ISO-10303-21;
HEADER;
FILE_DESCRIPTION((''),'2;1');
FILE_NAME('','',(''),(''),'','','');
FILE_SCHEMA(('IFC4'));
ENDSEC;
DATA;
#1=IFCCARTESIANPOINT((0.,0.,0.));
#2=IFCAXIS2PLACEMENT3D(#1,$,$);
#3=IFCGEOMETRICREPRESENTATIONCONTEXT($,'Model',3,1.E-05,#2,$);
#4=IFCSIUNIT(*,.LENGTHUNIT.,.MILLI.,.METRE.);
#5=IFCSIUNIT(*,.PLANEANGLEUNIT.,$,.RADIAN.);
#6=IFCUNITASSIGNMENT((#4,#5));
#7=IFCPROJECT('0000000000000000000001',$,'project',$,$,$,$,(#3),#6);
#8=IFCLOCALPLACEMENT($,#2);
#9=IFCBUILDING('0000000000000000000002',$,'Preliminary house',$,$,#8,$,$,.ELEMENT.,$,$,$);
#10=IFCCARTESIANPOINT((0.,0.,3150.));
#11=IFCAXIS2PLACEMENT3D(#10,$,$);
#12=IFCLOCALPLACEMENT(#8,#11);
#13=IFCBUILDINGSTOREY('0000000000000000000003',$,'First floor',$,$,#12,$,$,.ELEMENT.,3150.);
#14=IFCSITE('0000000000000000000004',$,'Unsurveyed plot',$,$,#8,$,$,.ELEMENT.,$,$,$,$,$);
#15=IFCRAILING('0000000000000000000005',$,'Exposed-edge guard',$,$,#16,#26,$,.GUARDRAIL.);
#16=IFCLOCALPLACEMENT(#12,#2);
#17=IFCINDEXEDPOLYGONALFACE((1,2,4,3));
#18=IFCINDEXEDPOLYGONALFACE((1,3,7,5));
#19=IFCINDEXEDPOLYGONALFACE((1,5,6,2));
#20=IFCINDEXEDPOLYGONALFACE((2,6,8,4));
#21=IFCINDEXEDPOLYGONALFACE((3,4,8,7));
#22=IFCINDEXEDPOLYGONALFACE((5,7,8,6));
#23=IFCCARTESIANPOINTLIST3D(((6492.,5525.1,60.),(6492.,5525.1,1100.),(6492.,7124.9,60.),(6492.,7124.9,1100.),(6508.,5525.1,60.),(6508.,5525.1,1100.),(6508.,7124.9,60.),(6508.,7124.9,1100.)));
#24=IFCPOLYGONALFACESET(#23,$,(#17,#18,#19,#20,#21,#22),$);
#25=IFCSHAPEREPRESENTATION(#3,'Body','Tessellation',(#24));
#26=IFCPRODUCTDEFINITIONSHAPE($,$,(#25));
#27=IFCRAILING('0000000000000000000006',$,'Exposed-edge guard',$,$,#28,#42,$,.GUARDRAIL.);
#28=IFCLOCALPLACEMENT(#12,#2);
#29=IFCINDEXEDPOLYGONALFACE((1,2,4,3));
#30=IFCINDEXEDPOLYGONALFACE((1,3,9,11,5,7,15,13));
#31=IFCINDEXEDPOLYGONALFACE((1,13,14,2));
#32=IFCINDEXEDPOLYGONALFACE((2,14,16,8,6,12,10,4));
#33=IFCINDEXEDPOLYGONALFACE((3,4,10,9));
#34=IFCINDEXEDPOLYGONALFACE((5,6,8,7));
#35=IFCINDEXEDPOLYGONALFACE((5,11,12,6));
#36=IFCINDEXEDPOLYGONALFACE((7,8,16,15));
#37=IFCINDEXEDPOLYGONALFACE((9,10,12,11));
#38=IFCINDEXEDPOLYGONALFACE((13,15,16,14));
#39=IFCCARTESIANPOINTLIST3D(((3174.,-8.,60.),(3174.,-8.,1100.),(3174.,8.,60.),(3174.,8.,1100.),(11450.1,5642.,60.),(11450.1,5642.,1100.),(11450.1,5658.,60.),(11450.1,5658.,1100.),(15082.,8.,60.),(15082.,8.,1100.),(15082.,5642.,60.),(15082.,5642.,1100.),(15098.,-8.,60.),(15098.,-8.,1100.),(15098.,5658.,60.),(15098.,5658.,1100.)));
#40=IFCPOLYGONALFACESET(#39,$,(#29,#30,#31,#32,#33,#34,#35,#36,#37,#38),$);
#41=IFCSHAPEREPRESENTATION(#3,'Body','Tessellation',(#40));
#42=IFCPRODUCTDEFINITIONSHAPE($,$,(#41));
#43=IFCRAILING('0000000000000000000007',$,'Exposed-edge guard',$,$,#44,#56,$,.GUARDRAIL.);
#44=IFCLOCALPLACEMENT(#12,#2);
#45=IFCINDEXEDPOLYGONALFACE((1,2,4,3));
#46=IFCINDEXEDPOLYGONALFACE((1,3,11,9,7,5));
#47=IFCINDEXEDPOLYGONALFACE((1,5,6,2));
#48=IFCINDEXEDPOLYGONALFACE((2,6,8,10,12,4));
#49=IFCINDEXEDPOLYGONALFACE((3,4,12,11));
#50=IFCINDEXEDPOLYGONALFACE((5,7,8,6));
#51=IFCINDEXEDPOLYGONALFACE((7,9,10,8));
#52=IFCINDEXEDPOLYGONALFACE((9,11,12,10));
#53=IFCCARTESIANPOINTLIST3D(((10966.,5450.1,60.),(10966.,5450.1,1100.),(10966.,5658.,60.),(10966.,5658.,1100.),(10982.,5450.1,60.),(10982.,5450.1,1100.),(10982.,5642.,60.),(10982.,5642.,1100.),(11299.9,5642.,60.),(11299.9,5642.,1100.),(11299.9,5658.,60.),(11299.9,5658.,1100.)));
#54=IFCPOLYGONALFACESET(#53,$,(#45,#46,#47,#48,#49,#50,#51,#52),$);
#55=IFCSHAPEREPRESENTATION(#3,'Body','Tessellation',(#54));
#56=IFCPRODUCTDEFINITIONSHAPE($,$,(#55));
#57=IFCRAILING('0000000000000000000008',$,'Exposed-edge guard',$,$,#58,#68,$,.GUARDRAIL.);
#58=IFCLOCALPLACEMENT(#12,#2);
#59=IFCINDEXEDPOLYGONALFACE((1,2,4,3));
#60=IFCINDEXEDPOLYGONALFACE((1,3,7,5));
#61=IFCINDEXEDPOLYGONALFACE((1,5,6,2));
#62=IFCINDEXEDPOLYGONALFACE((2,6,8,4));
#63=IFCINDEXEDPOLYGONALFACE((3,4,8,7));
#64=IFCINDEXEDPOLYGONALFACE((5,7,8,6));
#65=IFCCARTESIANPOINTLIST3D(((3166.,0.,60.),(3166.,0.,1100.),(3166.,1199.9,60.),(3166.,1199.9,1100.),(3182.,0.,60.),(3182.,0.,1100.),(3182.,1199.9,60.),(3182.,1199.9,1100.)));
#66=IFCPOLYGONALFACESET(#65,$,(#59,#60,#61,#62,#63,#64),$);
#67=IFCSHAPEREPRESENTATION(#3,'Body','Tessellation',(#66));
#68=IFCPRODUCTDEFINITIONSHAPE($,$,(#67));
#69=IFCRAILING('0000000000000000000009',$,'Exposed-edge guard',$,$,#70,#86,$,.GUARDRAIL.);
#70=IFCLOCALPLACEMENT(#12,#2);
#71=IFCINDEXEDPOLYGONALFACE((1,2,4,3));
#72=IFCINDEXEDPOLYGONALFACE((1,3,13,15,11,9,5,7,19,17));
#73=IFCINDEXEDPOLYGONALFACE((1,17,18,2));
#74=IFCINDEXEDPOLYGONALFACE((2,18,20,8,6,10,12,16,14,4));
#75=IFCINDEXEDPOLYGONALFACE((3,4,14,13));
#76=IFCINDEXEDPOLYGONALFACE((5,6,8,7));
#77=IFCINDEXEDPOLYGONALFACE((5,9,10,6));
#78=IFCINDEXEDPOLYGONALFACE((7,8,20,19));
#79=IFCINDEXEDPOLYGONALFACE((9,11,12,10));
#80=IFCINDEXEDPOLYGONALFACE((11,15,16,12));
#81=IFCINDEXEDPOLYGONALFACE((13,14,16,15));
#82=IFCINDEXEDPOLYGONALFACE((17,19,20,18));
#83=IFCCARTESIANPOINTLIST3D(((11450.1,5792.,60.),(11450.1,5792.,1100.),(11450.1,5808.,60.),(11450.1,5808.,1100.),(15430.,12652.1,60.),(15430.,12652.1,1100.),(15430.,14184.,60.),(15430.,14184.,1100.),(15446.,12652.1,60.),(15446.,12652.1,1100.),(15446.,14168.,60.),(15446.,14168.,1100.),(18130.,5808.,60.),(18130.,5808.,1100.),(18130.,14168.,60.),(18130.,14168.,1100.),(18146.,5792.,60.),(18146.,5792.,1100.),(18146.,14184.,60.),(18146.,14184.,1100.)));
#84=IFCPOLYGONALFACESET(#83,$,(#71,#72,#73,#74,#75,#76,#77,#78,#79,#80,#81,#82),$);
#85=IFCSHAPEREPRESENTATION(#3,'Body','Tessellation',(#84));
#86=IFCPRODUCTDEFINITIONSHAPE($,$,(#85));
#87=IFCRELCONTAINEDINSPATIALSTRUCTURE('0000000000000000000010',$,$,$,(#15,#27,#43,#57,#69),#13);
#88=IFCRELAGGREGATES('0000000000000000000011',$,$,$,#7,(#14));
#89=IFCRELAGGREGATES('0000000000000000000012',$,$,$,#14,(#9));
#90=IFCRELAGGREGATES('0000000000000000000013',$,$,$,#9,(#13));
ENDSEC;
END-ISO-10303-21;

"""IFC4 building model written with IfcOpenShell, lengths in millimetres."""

from ifc_helpers import new_model, si_unit, frame, origin, place, context, project, spatial, polyline, outline, extrude, element, save


model = new_model("IFC4")

# Units and contexts
model_context = context("Model", 3, precision=1e-05, world=origin())
ifc_project = project(units=[si_unit("LENGTHUNIT", "METRE", prefix="MILLI"), si_unit("PLANEANGLEUNIT", "RADIAN")], contexts=[model_context])

# Site, building, storey
placement_1 = place(None, origin())
site = spatial("IfcSite", under=ifc_project, at=placement_1, Name="Unsurveyed plot", CompositionType="ELEMENT")
building = spatial("IfcBuilding", under=site, at=placement_1, Name="Preliminary house", CompositionType="ELEMENT")
placement_2 = place(placement_1, frame((0.0, 0.0, 3150.0)))
storey = spatial("IfcBuildingStorey", under=building, at=placement_2, Name="First floor", CompositionType="ELEMENT", Elevation=3150.0)

# Railings
element("IfcRailing", 1, at=placement_2, inside=storey, Name="Exposed-edge guard", PredefinedType="GUARDRAIL", context=model_context, shape_type="SweptSolid", body=[
    extrude(outline(polyline([(6508.0, 5525.1), (6492.0, 5525.1), (6492.0, 7124.9), (6508.0, 7124.9), (6508.0, 5525.1)])), frame((0.0, 0.0, 60.0)), (0.0, 0.0, 1.0), 1040.0),
])
element("IfcRailing", 2, at=placement_2, inside=storey, Name="Exposed-edge guard", PredefinedType="GUARDRAIL", context=model_context, shape_type="SweptSolid", body=[
    extrude(outline(polyline([(15082.0, 8.0), (15082.0, 5642.0), (11450.1, 5642.0), (11450.1, 5658.0), (15098.0, 5658.0), (15098.0, -8.0), (3174.0, -8.0), (3174.0, 8.0), (15082.0, 8.0)])), frame((0.0, 0.0, 60.0)), (0.0, 0.0, 1.0), 1040.0),
])
element("IfcRailing", 3, at=placement_2, inside=storey, Name="Exposed-edge guard", PredefinedType="GUARDRAIL", context=model_context, shape_type="SweptSolid", body=[
    extrude(outline(polyline([(10982.0, 5642.0), (10982.0, 5450.1), (10966.0, 5450.1), (10966.0, 5658.0), (11299.9, 5658.0), (11299.9, 5642.0), (10982.0, 5642.0)])), frame((0.0, 0.0, 60.0)), (0.0, 0.0, 1.0), 1040.0),
])
element("IfcRailing", 4, at=placement_2, inside=storey, Name="Exposed-edge guard", PredefinedType="GUARDRAIL", context=model_context, shape_type="SweptSolid", body=[
    extrude(outline(polyline([(3182.0, 0.0), (3166.0, 0.0), (3166.0, 1199.9), (3182.0, 1199.9), (3182.0, 0.0)])), frame((0.0, 0.0, 60.0)), (0.0, 0.0, 1.0), 1040.0),
])
element("IfcRailing", 5, at=placement_2, inside=storey, Name="Exposed-edge guard", PredefinedType="GUARDRAIL", context=model_context, shape_type="SweptSolid", body=[
    extrude(outline(polyline([(18130.0, 5808.0), (18130.0, 14168.0), (15446.0, 14168.0), (15446.0, 12652.1), (15430.0, 12652.1), (15430.0, 14184.0), (18146.0, 14184.0), (18146.0, 5792.0), (11450.1, 5792.0), (11450.1, 5808.0), (18130.0, 5808.0)])), frame((0.0, 0.0, 60.0)), (0.0, 0.0, 1.0), 1040.0),
])

save(model, "model.ifc")
